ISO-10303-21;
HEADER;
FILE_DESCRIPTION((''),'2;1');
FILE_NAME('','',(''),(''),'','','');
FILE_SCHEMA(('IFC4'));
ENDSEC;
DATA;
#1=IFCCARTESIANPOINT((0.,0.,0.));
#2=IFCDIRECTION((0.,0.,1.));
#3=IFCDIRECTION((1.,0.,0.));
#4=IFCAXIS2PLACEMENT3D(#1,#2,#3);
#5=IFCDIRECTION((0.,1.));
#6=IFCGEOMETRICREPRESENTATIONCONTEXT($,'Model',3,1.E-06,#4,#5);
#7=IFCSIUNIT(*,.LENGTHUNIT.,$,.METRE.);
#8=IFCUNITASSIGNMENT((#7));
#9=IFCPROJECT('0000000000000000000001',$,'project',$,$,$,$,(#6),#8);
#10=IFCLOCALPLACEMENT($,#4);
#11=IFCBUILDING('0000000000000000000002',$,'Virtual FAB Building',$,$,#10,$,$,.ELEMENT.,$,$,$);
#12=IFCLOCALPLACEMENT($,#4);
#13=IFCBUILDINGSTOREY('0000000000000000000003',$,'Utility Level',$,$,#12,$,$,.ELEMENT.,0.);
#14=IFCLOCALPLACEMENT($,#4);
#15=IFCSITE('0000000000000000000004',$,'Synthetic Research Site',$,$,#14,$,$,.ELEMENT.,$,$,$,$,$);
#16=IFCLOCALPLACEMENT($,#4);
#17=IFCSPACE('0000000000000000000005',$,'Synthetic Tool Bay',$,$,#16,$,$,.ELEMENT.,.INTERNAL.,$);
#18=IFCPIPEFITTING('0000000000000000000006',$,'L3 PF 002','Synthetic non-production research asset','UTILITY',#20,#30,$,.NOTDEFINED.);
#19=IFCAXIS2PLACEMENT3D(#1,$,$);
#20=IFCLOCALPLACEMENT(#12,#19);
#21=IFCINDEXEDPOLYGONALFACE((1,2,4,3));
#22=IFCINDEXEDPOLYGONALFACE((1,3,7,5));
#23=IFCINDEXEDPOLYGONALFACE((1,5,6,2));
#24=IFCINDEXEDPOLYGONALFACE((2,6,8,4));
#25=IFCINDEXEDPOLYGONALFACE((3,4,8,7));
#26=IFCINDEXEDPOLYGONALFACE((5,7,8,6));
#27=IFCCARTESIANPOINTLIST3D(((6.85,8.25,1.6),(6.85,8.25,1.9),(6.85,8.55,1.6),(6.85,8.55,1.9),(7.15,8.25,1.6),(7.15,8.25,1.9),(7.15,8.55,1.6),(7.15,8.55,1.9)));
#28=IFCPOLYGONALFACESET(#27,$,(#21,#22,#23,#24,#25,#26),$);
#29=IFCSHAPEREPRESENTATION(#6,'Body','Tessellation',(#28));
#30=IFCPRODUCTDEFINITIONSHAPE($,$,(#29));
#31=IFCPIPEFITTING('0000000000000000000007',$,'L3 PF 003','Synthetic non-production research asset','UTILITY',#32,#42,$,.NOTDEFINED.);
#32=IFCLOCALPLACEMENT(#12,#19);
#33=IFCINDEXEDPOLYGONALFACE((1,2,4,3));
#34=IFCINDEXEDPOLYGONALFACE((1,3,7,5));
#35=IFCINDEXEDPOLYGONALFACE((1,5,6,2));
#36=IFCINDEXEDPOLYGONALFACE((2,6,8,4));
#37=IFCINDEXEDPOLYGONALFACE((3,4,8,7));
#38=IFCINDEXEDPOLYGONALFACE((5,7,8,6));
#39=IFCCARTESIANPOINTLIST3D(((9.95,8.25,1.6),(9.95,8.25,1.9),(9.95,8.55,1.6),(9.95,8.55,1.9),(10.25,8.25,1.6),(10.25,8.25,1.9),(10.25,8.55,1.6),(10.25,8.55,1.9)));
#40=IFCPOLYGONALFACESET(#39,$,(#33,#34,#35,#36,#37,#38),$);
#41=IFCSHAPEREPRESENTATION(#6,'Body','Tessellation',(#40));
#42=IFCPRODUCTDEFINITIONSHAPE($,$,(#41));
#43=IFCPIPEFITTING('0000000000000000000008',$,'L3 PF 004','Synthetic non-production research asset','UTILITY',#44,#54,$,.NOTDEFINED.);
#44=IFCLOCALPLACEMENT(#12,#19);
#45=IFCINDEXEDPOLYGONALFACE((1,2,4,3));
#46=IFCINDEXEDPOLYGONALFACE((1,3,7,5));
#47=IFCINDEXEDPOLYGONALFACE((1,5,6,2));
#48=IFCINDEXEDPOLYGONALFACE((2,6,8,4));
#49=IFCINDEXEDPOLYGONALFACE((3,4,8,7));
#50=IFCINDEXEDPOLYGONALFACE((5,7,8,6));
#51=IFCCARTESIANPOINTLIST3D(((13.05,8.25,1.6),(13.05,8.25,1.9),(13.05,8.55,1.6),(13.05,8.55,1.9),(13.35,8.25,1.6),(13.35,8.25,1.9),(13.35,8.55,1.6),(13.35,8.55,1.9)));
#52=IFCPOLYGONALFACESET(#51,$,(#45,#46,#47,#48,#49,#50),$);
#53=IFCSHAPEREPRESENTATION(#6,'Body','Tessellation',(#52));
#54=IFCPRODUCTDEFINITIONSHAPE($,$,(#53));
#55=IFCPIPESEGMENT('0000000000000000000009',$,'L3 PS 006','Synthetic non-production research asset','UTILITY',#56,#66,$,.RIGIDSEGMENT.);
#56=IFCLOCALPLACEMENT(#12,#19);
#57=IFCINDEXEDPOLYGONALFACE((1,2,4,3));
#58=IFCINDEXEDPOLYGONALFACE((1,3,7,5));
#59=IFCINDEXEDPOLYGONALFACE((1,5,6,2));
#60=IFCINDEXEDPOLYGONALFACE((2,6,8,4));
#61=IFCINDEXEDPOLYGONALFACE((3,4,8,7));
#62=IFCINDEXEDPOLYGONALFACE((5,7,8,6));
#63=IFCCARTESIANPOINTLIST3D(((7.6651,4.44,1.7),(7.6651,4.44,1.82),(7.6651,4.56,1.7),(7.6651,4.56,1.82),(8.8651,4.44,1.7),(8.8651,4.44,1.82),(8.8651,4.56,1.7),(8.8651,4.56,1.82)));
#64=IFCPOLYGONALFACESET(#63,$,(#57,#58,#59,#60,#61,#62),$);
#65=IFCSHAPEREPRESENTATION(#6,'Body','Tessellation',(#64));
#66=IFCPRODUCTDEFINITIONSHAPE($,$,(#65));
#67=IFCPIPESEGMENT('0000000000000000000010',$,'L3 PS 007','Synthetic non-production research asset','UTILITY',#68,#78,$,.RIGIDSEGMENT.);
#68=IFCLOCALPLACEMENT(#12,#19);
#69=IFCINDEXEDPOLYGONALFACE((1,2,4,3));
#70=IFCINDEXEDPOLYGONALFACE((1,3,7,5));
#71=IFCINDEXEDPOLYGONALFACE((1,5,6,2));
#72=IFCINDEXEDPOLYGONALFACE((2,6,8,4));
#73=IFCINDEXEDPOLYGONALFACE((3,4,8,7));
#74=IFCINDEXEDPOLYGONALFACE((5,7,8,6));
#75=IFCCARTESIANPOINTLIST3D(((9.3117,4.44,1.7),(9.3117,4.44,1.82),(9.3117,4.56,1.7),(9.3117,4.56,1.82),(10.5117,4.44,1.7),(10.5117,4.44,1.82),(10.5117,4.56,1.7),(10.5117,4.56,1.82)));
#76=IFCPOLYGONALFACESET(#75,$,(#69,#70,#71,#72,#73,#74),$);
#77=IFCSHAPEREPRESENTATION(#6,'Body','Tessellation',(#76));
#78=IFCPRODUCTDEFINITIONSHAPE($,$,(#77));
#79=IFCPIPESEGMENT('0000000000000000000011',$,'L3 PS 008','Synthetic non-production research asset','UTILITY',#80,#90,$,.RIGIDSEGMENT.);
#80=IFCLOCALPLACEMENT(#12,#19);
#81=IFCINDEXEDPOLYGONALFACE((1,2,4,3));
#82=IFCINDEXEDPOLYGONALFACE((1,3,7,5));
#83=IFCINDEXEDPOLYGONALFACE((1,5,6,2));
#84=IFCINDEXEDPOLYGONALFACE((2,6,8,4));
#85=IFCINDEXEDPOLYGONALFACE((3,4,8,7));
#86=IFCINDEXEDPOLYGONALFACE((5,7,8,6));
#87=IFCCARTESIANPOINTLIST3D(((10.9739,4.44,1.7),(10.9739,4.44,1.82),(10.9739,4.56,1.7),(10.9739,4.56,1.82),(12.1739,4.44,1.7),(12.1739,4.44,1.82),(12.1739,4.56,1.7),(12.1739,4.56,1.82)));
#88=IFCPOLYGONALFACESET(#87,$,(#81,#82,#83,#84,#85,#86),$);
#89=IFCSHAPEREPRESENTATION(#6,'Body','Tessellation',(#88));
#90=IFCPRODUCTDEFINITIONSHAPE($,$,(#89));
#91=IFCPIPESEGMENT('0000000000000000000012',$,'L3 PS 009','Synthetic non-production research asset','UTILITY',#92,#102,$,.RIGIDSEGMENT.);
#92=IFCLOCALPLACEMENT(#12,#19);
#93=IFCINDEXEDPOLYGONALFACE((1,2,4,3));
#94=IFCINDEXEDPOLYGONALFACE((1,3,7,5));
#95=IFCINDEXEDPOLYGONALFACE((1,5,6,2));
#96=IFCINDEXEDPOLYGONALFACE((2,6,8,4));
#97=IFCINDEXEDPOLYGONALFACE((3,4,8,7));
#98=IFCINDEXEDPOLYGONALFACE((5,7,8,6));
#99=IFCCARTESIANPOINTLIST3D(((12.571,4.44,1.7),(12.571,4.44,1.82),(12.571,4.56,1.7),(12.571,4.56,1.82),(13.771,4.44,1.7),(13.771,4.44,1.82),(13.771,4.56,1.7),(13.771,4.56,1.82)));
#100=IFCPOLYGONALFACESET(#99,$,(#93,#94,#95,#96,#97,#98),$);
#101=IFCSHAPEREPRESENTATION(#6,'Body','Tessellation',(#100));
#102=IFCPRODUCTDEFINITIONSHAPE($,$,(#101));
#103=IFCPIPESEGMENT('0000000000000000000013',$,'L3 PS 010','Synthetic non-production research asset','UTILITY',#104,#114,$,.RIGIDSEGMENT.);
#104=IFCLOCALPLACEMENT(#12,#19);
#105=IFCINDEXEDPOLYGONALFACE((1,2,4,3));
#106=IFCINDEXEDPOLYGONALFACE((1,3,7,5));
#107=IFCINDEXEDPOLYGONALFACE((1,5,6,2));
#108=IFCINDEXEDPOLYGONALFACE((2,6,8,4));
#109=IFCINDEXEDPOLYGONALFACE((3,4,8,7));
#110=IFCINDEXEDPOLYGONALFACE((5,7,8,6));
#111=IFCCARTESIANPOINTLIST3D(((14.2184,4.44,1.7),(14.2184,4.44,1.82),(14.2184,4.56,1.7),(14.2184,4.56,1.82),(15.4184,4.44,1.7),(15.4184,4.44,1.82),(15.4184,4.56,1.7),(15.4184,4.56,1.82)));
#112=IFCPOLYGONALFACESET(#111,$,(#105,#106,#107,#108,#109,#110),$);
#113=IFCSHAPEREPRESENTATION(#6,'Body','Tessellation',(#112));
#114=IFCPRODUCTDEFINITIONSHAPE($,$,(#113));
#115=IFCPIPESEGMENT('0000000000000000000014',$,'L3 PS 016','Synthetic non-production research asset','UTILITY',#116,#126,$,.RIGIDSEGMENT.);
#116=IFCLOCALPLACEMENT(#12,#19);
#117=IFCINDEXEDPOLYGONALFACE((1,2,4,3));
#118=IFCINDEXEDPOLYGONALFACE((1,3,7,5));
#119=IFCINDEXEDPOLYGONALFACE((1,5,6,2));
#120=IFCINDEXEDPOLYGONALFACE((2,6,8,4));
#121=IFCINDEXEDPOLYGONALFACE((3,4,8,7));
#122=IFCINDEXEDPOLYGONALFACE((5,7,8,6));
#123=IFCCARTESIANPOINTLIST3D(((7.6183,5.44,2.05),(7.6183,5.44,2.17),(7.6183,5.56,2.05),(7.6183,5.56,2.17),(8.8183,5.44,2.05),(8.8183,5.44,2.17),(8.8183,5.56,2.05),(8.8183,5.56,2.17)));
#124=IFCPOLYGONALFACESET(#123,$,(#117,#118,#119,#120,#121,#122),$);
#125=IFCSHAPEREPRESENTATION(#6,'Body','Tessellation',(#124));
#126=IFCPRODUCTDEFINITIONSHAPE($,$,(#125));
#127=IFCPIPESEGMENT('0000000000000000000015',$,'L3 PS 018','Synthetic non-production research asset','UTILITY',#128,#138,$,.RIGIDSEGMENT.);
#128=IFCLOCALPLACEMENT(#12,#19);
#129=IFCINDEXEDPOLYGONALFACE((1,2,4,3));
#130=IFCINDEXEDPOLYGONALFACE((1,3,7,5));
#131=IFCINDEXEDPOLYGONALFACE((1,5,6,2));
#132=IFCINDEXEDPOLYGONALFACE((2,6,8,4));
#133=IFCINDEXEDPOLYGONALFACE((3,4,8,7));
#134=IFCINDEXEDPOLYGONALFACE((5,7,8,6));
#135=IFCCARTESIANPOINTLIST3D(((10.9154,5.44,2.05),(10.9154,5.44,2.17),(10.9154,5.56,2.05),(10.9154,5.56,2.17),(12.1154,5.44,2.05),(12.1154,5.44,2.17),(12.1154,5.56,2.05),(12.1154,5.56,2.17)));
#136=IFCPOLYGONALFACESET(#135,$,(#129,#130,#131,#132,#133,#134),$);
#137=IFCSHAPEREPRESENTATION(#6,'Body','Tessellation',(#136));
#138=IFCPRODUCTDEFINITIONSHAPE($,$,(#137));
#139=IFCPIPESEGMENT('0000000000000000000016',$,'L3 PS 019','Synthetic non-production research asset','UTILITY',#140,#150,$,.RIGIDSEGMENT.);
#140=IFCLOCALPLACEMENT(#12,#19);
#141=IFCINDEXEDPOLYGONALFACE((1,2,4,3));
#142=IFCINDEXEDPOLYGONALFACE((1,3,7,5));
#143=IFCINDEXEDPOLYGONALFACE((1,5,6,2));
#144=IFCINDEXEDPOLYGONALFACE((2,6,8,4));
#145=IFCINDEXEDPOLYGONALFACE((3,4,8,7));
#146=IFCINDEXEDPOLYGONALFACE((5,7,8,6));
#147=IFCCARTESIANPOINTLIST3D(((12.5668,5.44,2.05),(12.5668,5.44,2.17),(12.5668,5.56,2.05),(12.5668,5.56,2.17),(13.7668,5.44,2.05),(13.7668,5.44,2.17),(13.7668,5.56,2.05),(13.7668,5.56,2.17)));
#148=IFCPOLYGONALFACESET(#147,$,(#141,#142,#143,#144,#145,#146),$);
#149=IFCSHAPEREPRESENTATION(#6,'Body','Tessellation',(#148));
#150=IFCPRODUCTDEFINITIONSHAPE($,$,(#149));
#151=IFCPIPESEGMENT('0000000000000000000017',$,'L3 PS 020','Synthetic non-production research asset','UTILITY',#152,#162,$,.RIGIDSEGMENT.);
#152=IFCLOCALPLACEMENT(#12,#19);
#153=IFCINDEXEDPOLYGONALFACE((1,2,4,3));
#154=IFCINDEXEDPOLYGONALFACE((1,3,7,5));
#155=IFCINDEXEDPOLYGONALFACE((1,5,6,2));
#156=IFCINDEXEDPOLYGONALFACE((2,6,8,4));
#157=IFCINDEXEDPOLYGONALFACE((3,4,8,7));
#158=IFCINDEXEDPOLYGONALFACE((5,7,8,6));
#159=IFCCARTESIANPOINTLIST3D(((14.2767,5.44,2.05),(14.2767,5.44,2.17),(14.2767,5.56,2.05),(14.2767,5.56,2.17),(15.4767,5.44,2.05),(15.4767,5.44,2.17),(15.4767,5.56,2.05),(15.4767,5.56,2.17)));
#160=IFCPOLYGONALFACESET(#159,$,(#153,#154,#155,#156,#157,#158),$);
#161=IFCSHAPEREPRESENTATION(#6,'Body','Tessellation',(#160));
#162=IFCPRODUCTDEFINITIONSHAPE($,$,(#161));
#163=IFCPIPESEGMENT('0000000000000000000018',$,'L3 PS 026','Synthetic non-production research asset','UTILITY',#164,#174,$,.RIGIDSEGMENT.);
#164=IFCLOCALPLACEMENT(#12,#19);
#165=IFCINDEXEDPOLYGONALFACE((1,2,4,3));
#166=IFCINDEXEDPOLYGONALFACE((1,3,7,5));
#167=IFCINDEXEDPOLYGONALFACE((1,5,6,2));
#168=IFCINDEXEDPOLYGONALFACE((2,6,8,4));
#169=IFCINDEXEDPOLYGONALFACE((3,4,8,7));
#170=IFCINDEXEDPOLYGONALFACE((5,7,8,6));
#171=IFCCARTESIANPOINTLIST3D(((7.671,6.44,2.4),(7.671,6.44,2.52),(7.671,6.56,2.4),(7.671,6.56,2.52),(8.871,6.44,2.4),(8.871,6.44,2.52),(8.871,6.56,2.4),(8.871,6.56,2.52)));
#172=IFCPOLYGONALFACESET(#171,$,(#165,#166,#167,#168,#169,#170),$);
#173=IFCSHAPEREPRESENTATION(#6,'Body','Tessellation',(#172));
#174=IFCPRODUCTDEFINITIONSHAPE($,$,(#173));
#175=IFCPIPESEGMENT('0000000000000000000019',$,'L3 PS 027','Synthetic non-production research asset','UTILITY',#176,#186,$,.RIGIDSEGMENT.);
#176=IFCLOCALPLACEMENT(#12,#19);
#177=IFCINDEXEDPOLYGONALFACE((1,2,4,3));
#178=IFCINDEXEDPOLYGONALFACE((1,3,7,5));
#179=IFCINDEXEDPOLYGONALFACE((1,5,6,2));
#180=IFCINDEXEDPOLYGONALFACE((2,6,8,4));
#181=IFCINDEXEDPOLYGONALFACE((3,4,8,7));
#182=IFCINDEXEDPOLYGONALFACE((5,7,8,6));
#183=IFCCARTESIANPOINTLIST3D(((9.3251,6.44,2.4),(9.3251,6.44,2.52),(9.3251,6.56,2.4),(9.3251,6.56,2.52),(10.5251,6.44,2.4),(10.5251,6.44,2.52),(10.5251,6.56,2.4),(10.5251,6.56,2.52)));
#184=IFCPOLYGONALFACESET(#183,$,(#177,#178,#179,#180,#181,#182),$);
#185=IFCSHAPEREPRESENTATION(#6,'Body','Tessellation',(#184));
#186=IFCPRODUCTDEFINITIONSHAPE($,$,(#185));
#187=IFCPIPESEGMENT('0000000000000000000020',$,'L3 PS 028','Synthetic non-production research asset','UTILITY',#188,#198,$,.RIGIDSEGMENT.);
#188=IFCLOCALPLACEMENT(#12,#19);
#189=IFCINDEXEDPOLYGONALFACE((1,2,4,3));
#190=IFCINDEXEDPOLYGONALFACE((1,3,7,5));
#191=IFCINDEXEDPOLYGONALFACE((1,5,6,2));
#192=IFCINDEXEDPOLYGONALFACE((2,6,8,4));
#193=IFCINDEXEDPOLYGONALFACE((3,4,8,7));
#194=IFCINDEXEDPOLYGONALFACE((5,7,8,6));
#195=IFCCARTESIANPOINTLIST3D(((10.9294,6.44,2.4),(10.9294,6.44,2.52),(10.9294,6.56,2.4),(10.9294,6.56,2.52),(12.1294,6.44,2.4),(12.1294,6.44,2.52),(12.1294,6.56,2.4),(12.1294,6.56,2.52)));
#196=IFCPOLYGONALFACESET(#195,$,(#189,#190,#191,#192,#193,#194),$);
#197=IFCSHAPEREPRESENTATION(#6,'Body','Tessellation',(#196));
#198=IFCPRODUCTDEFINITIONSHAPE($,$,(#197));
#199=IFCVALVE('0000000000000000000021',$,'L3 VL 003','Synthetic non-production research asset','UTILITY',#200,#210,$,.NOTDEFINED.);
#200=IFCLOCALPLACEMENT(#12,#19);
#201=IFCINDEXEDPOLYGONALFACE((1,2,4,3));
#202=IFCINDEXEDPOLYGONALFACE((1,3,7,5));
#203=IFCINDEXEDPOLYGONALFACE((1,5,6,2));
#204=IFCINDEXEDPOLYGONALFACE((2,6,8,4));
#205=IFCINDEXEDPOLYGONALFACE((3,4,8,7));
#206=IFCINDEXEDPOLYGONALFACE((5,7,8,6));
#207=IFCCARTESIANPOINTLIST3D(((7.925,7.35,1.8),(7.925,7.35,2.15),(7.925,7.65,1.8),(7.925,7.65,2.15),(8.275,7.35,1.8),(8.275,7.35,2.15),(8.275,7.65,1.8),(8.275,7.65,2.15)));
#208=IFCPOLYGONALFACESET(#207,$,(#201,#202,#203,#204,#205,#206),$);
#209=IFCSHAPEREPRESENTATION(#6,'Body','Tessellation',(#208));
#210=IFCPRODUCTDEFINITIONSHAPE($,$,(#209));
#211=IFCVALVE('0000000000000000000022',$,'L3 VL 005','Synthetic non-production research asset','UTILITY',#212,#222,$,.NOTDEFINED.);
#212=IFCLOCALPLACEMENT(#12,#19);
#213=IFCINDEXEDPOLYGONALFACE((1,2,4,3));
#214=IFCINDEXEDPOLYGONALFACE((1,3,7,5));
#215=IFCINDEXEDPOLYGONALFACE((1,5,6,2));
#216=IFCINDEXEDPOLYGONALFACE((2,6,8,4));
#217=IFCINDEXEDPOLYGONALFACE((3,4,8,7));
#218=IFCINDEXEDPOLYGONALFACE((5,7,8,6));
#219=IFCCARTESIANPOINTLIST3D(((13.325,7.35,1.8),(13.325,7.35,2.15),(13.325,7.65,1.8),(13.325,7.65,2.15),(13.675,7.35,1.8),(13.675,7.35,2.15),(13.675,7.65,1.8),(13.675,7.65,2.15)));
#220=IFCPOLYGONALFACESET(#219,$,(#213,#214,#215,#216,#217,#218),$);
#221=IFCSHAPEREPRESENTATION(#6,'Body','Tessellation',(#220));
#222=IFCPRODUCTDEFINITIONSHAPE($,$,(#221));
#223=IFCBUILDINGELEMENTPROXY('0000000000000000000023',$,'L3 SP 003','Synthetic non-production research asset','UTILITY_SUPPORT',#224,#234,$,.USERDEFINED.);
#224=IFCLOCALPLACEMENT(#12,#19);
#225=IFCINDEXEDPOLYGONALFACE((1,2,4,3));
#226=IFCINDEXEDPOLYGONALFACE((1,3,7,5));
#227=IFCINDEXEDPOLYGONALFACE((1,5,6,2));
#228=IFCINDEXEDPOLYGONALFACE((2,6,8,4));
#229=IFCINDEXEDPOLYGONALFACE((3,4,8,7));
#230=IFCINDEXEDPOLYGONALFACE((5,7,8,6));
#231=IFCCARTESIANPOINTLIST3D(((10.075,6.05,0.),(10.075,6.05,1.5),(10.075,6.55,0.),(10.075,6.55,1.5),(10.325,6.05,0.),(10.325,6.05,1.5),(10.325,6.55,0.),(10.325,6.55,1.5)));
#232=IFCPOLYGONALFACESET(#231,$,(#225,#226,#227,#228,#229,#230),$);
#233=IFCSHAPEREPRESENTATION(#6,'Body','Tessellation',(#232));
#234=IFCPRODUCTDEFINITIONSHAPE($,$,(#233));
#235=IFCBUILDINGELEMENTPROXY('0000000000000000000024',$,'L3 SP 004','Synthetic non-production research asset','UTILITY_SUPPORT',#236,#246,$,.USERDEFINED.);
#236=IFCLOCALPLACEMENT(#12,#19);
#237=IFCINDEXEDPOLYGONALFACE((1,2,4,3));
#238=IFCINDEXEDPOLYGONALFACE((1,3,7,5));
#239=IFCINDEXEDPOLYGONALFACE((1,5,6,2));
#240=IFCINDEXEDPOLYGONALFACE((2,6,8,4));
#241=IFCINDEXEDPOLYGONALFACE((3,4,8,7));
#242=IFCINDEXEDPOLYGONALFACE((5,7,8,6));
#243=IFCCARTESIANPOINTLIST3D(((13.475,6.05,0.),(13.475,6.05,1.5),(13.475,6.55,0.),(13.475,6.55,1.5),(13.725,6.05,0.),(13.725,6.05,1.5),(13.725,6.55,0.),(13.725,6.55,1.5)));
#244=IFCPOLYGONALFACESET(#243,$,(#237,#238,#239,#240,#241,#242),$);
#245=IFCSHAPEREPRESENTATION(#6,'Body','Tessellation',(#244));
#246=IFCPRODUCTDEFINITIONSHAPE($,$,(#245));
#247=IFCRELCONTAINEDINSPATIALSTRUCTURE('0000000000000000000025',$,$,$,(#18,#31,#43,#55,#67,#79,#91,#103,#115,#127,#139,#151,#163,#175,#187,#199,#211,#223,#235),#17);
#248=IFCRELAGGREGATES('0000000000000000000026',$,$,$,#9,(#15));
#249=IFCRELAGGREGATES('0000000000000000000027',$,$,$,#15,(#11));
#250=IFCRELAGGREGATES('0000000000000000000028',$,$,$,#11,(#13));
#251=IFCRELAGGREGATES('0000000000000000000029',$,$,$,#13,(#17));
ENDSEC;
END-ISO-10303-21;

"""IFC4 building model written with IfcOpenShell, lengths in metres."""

from ifc_helpers import new_model, si_unit, direction, frame, origin_with_axes, origin_2d_with_axis, place, context, project, spatial, rectangle, extrude, element, save


model = new_model("IFC4")

# Units and contexts
model_context = context("Model", 3, precision=1e-06, world=origin_with_axes(), true_north=direction((0.0, 1.0)))
ifc_project = project(units=[si_unit("LENGTHUNIT", "METRE")], contexts=[model_context])

# Site, building, storey, space
site_placement = place(None, origin_with_axes())
site = spatial("IfcSite", under=ifc_project, at=site_placement, Name="Synthetic Research Site", CompositionType="ELEMENT")
building_placement = place(None, origin_with_axes())
building = spatial("IfcBuilding", under=site, at=building_placement, Name="Virtual FAB Building", CompositionType="ELEMENT")
storey_placement = place(None, origin_with_axes())
storey = spatial("IfcBuildingStorey", under=building, at=storey_placement, Name="Utility Level", CompositionType="ELEMENT", Elevation=0.0)
space_placement = place(None, origin_with_axes())
space = spatial("IfcSpace", under=storey, at=space_placement, Name="Synthetic Tool Bay", CompositionType="ELEMENT", PredefinedType="INTERNAL")

# Pipe fittings
for number, where, z_axis, x_axis, name in (
    (1, (7.0, 8.4, 1.6), (0.0, 0.0, 1.0), (1.0, 0.0, 0.0), "L3 PF 002"),
    (2, (10.1, 8.4, 1.6), (0.0, 0.0, 1.0), (1.0, 0.0, 0.0), "L3 PF 003"),
    (3, (13.2, 8.4, 1.6), (0.0, 0.0, 1.0), (1.0, 0.0, 0.0), "L3 PF 004"),
):
    element("IfcPipeFitting", number, at=place(None, frame(where, z_axis=z_axis, x_axis=x_axis)), inside=space, Name=name, Description="Synthetic non-production research asset", ObjectType="UTILITY", PredefinedType="NOTDEFINED", context=model_context, shape_type="SweptSolid", body=[
        extrude(rectangle(XDim=0.3, YDim=0.3, at=origin_2d_with_axis()), origin_with_axes(), (0.0, 0.0, 1.0), 0.3),
    ])

# Pipe segments
for number, where, z_axis, x_axis, name in (
    (4, (8.2651, 4.5, 1.7), (0.0, 0.0, 1.0), (1.0, 0.0, 0.0), "L3 PS 006"),
    (5, (9.9117, 4.5, 1.7), (0.0, 0.0, 1.0), (1.0, 0.0, 0.0), "L3 PS 007"),
    (6, (11.5739, 4.5, 1.7), (0.0, 0.0, 1.0), (1.0, 0.0, 0.0), "L3 PS 008"),
    (7, (13.171, 4.5, 1.7), (0.0, 0.0, 1.0), (1.0, 0.0, 0.0), "L3 PS 009"),
    (8, (14.8184, 4.5, 1.7), (0.0, 0.0, 1.0), (1.0, 0.0, 0.0), "L3 PS 010"),
    (9, (8.2183, 5.5, 2.05), (0.0, 0.0, 1.0), (1.0, 0.0, 0.0), "L3 PS 016"),
    (10, (11.5154, 5.5, 2.05), (0.0, 0.0, 1.0), (1.0, 0.0, 0.0), "L3 PS 018"),
    (11, (13.1668, 5.5, 2.05), (0.0, 0.0, 1.0), (1.0, 0.0, 0.0), "L3 PS 019"),
    (12, (14.8767, 5.5, 2.05), (0.0, 0.0, 1.0), (1.0, 0.0, 0.0), "L3 PS 020"),
    (13, (8.271, 6.5, 2.4), (0.0, 0.0, 1.0), (1.0, 0.0, 0.0), "L3 PS 026"),
    (14, (9.9251, 6.5, 2.4), (0.0, 0.0, 1.0), (1.0, 0.0, 0.0), "L3 PS 027"),
    (15, (11.5294, 6.5, 2.4), (0.0, 0.0, 1.0), (1.0, 0.0, 0.0), "L3 PS 028"),
):
    element("IfcPipeSegment", number, at=place(None, frame(where, z_axis=z_axis, x_axis=x_axis)), inside=space, Name=name, Description="Synthetic non-production research asset", ObjectType="UTILITY", PredefinedType="RIGIDSEGMENT", context=model_context, shape_type="SweptSolid", body=[
        extrude(rectangle(XDim=1.2, YDim=0.12, at=origin_2d_with_axis()), origin_with_axes(), (0.0, 0.0, 1.0), 0.12),
    ])

# Valves
for number, where, z_axis, x_axis, name in (
    (16, (8.1, 7.5, 1.8), (0.0, 0.0, 1.0), (1.0, 0.0, 0.0), "L3 VL 003"),
    (17, (13.5, 7.5, 1.8), (0.0, 0.0, 1.0), (1.0, 0.0, 0.0), "L3 VL 005"),
):
    element("IfcValve", number, at=place(None, frame(where, z_axis=z_axis, x_axis=x_axis)), inside=space, Name=name, Description="Synthetic non-production research asset", ObjectType="UTILITY", PredefinedType="NOTDEFINED", context=model_context, shape_type="SweptSolid", body=[
        extrude(rectangle(XDim=0.35, YDim=0.3, at=origin_2d_with_axis()), origin_with_axes(), (0.0, 0.0, 1.0), 0.35),
    ])

# Building element proxies
for number, where, z_axis, x_axis, name in (
    (18, (10.2, 6.3, 0.0), (0.0, 0.0, 1.0), (1.0, 0.0, 0.0), "L3 SP 003"),
    (19, (13.6, 6.3, 0.0), (0.0, 0.0, 1.0), (1.0, 0.0, 0.0), "L3 SP 004"),
):
    element("IfcBuildingElementProxy", number, at=place(None, frame(where, z_axis=z_axis, x_axis=x_axis)), inside=space, Name=name, Description="Synthetic non-production research asset", ObjectType="UTILITY_SUPPORT", PredefinedType="USERDEFINED", context=model_context, shape_type="SweptSolid", body=[
        extrude(rectangle(XDim=0.25, YDim=0.5, at=origin_2d_with_axis()), origin_with_axes(), (0.0, 0.0, 1.0), 1.5),
    ])

save(model, "model.ifc")
